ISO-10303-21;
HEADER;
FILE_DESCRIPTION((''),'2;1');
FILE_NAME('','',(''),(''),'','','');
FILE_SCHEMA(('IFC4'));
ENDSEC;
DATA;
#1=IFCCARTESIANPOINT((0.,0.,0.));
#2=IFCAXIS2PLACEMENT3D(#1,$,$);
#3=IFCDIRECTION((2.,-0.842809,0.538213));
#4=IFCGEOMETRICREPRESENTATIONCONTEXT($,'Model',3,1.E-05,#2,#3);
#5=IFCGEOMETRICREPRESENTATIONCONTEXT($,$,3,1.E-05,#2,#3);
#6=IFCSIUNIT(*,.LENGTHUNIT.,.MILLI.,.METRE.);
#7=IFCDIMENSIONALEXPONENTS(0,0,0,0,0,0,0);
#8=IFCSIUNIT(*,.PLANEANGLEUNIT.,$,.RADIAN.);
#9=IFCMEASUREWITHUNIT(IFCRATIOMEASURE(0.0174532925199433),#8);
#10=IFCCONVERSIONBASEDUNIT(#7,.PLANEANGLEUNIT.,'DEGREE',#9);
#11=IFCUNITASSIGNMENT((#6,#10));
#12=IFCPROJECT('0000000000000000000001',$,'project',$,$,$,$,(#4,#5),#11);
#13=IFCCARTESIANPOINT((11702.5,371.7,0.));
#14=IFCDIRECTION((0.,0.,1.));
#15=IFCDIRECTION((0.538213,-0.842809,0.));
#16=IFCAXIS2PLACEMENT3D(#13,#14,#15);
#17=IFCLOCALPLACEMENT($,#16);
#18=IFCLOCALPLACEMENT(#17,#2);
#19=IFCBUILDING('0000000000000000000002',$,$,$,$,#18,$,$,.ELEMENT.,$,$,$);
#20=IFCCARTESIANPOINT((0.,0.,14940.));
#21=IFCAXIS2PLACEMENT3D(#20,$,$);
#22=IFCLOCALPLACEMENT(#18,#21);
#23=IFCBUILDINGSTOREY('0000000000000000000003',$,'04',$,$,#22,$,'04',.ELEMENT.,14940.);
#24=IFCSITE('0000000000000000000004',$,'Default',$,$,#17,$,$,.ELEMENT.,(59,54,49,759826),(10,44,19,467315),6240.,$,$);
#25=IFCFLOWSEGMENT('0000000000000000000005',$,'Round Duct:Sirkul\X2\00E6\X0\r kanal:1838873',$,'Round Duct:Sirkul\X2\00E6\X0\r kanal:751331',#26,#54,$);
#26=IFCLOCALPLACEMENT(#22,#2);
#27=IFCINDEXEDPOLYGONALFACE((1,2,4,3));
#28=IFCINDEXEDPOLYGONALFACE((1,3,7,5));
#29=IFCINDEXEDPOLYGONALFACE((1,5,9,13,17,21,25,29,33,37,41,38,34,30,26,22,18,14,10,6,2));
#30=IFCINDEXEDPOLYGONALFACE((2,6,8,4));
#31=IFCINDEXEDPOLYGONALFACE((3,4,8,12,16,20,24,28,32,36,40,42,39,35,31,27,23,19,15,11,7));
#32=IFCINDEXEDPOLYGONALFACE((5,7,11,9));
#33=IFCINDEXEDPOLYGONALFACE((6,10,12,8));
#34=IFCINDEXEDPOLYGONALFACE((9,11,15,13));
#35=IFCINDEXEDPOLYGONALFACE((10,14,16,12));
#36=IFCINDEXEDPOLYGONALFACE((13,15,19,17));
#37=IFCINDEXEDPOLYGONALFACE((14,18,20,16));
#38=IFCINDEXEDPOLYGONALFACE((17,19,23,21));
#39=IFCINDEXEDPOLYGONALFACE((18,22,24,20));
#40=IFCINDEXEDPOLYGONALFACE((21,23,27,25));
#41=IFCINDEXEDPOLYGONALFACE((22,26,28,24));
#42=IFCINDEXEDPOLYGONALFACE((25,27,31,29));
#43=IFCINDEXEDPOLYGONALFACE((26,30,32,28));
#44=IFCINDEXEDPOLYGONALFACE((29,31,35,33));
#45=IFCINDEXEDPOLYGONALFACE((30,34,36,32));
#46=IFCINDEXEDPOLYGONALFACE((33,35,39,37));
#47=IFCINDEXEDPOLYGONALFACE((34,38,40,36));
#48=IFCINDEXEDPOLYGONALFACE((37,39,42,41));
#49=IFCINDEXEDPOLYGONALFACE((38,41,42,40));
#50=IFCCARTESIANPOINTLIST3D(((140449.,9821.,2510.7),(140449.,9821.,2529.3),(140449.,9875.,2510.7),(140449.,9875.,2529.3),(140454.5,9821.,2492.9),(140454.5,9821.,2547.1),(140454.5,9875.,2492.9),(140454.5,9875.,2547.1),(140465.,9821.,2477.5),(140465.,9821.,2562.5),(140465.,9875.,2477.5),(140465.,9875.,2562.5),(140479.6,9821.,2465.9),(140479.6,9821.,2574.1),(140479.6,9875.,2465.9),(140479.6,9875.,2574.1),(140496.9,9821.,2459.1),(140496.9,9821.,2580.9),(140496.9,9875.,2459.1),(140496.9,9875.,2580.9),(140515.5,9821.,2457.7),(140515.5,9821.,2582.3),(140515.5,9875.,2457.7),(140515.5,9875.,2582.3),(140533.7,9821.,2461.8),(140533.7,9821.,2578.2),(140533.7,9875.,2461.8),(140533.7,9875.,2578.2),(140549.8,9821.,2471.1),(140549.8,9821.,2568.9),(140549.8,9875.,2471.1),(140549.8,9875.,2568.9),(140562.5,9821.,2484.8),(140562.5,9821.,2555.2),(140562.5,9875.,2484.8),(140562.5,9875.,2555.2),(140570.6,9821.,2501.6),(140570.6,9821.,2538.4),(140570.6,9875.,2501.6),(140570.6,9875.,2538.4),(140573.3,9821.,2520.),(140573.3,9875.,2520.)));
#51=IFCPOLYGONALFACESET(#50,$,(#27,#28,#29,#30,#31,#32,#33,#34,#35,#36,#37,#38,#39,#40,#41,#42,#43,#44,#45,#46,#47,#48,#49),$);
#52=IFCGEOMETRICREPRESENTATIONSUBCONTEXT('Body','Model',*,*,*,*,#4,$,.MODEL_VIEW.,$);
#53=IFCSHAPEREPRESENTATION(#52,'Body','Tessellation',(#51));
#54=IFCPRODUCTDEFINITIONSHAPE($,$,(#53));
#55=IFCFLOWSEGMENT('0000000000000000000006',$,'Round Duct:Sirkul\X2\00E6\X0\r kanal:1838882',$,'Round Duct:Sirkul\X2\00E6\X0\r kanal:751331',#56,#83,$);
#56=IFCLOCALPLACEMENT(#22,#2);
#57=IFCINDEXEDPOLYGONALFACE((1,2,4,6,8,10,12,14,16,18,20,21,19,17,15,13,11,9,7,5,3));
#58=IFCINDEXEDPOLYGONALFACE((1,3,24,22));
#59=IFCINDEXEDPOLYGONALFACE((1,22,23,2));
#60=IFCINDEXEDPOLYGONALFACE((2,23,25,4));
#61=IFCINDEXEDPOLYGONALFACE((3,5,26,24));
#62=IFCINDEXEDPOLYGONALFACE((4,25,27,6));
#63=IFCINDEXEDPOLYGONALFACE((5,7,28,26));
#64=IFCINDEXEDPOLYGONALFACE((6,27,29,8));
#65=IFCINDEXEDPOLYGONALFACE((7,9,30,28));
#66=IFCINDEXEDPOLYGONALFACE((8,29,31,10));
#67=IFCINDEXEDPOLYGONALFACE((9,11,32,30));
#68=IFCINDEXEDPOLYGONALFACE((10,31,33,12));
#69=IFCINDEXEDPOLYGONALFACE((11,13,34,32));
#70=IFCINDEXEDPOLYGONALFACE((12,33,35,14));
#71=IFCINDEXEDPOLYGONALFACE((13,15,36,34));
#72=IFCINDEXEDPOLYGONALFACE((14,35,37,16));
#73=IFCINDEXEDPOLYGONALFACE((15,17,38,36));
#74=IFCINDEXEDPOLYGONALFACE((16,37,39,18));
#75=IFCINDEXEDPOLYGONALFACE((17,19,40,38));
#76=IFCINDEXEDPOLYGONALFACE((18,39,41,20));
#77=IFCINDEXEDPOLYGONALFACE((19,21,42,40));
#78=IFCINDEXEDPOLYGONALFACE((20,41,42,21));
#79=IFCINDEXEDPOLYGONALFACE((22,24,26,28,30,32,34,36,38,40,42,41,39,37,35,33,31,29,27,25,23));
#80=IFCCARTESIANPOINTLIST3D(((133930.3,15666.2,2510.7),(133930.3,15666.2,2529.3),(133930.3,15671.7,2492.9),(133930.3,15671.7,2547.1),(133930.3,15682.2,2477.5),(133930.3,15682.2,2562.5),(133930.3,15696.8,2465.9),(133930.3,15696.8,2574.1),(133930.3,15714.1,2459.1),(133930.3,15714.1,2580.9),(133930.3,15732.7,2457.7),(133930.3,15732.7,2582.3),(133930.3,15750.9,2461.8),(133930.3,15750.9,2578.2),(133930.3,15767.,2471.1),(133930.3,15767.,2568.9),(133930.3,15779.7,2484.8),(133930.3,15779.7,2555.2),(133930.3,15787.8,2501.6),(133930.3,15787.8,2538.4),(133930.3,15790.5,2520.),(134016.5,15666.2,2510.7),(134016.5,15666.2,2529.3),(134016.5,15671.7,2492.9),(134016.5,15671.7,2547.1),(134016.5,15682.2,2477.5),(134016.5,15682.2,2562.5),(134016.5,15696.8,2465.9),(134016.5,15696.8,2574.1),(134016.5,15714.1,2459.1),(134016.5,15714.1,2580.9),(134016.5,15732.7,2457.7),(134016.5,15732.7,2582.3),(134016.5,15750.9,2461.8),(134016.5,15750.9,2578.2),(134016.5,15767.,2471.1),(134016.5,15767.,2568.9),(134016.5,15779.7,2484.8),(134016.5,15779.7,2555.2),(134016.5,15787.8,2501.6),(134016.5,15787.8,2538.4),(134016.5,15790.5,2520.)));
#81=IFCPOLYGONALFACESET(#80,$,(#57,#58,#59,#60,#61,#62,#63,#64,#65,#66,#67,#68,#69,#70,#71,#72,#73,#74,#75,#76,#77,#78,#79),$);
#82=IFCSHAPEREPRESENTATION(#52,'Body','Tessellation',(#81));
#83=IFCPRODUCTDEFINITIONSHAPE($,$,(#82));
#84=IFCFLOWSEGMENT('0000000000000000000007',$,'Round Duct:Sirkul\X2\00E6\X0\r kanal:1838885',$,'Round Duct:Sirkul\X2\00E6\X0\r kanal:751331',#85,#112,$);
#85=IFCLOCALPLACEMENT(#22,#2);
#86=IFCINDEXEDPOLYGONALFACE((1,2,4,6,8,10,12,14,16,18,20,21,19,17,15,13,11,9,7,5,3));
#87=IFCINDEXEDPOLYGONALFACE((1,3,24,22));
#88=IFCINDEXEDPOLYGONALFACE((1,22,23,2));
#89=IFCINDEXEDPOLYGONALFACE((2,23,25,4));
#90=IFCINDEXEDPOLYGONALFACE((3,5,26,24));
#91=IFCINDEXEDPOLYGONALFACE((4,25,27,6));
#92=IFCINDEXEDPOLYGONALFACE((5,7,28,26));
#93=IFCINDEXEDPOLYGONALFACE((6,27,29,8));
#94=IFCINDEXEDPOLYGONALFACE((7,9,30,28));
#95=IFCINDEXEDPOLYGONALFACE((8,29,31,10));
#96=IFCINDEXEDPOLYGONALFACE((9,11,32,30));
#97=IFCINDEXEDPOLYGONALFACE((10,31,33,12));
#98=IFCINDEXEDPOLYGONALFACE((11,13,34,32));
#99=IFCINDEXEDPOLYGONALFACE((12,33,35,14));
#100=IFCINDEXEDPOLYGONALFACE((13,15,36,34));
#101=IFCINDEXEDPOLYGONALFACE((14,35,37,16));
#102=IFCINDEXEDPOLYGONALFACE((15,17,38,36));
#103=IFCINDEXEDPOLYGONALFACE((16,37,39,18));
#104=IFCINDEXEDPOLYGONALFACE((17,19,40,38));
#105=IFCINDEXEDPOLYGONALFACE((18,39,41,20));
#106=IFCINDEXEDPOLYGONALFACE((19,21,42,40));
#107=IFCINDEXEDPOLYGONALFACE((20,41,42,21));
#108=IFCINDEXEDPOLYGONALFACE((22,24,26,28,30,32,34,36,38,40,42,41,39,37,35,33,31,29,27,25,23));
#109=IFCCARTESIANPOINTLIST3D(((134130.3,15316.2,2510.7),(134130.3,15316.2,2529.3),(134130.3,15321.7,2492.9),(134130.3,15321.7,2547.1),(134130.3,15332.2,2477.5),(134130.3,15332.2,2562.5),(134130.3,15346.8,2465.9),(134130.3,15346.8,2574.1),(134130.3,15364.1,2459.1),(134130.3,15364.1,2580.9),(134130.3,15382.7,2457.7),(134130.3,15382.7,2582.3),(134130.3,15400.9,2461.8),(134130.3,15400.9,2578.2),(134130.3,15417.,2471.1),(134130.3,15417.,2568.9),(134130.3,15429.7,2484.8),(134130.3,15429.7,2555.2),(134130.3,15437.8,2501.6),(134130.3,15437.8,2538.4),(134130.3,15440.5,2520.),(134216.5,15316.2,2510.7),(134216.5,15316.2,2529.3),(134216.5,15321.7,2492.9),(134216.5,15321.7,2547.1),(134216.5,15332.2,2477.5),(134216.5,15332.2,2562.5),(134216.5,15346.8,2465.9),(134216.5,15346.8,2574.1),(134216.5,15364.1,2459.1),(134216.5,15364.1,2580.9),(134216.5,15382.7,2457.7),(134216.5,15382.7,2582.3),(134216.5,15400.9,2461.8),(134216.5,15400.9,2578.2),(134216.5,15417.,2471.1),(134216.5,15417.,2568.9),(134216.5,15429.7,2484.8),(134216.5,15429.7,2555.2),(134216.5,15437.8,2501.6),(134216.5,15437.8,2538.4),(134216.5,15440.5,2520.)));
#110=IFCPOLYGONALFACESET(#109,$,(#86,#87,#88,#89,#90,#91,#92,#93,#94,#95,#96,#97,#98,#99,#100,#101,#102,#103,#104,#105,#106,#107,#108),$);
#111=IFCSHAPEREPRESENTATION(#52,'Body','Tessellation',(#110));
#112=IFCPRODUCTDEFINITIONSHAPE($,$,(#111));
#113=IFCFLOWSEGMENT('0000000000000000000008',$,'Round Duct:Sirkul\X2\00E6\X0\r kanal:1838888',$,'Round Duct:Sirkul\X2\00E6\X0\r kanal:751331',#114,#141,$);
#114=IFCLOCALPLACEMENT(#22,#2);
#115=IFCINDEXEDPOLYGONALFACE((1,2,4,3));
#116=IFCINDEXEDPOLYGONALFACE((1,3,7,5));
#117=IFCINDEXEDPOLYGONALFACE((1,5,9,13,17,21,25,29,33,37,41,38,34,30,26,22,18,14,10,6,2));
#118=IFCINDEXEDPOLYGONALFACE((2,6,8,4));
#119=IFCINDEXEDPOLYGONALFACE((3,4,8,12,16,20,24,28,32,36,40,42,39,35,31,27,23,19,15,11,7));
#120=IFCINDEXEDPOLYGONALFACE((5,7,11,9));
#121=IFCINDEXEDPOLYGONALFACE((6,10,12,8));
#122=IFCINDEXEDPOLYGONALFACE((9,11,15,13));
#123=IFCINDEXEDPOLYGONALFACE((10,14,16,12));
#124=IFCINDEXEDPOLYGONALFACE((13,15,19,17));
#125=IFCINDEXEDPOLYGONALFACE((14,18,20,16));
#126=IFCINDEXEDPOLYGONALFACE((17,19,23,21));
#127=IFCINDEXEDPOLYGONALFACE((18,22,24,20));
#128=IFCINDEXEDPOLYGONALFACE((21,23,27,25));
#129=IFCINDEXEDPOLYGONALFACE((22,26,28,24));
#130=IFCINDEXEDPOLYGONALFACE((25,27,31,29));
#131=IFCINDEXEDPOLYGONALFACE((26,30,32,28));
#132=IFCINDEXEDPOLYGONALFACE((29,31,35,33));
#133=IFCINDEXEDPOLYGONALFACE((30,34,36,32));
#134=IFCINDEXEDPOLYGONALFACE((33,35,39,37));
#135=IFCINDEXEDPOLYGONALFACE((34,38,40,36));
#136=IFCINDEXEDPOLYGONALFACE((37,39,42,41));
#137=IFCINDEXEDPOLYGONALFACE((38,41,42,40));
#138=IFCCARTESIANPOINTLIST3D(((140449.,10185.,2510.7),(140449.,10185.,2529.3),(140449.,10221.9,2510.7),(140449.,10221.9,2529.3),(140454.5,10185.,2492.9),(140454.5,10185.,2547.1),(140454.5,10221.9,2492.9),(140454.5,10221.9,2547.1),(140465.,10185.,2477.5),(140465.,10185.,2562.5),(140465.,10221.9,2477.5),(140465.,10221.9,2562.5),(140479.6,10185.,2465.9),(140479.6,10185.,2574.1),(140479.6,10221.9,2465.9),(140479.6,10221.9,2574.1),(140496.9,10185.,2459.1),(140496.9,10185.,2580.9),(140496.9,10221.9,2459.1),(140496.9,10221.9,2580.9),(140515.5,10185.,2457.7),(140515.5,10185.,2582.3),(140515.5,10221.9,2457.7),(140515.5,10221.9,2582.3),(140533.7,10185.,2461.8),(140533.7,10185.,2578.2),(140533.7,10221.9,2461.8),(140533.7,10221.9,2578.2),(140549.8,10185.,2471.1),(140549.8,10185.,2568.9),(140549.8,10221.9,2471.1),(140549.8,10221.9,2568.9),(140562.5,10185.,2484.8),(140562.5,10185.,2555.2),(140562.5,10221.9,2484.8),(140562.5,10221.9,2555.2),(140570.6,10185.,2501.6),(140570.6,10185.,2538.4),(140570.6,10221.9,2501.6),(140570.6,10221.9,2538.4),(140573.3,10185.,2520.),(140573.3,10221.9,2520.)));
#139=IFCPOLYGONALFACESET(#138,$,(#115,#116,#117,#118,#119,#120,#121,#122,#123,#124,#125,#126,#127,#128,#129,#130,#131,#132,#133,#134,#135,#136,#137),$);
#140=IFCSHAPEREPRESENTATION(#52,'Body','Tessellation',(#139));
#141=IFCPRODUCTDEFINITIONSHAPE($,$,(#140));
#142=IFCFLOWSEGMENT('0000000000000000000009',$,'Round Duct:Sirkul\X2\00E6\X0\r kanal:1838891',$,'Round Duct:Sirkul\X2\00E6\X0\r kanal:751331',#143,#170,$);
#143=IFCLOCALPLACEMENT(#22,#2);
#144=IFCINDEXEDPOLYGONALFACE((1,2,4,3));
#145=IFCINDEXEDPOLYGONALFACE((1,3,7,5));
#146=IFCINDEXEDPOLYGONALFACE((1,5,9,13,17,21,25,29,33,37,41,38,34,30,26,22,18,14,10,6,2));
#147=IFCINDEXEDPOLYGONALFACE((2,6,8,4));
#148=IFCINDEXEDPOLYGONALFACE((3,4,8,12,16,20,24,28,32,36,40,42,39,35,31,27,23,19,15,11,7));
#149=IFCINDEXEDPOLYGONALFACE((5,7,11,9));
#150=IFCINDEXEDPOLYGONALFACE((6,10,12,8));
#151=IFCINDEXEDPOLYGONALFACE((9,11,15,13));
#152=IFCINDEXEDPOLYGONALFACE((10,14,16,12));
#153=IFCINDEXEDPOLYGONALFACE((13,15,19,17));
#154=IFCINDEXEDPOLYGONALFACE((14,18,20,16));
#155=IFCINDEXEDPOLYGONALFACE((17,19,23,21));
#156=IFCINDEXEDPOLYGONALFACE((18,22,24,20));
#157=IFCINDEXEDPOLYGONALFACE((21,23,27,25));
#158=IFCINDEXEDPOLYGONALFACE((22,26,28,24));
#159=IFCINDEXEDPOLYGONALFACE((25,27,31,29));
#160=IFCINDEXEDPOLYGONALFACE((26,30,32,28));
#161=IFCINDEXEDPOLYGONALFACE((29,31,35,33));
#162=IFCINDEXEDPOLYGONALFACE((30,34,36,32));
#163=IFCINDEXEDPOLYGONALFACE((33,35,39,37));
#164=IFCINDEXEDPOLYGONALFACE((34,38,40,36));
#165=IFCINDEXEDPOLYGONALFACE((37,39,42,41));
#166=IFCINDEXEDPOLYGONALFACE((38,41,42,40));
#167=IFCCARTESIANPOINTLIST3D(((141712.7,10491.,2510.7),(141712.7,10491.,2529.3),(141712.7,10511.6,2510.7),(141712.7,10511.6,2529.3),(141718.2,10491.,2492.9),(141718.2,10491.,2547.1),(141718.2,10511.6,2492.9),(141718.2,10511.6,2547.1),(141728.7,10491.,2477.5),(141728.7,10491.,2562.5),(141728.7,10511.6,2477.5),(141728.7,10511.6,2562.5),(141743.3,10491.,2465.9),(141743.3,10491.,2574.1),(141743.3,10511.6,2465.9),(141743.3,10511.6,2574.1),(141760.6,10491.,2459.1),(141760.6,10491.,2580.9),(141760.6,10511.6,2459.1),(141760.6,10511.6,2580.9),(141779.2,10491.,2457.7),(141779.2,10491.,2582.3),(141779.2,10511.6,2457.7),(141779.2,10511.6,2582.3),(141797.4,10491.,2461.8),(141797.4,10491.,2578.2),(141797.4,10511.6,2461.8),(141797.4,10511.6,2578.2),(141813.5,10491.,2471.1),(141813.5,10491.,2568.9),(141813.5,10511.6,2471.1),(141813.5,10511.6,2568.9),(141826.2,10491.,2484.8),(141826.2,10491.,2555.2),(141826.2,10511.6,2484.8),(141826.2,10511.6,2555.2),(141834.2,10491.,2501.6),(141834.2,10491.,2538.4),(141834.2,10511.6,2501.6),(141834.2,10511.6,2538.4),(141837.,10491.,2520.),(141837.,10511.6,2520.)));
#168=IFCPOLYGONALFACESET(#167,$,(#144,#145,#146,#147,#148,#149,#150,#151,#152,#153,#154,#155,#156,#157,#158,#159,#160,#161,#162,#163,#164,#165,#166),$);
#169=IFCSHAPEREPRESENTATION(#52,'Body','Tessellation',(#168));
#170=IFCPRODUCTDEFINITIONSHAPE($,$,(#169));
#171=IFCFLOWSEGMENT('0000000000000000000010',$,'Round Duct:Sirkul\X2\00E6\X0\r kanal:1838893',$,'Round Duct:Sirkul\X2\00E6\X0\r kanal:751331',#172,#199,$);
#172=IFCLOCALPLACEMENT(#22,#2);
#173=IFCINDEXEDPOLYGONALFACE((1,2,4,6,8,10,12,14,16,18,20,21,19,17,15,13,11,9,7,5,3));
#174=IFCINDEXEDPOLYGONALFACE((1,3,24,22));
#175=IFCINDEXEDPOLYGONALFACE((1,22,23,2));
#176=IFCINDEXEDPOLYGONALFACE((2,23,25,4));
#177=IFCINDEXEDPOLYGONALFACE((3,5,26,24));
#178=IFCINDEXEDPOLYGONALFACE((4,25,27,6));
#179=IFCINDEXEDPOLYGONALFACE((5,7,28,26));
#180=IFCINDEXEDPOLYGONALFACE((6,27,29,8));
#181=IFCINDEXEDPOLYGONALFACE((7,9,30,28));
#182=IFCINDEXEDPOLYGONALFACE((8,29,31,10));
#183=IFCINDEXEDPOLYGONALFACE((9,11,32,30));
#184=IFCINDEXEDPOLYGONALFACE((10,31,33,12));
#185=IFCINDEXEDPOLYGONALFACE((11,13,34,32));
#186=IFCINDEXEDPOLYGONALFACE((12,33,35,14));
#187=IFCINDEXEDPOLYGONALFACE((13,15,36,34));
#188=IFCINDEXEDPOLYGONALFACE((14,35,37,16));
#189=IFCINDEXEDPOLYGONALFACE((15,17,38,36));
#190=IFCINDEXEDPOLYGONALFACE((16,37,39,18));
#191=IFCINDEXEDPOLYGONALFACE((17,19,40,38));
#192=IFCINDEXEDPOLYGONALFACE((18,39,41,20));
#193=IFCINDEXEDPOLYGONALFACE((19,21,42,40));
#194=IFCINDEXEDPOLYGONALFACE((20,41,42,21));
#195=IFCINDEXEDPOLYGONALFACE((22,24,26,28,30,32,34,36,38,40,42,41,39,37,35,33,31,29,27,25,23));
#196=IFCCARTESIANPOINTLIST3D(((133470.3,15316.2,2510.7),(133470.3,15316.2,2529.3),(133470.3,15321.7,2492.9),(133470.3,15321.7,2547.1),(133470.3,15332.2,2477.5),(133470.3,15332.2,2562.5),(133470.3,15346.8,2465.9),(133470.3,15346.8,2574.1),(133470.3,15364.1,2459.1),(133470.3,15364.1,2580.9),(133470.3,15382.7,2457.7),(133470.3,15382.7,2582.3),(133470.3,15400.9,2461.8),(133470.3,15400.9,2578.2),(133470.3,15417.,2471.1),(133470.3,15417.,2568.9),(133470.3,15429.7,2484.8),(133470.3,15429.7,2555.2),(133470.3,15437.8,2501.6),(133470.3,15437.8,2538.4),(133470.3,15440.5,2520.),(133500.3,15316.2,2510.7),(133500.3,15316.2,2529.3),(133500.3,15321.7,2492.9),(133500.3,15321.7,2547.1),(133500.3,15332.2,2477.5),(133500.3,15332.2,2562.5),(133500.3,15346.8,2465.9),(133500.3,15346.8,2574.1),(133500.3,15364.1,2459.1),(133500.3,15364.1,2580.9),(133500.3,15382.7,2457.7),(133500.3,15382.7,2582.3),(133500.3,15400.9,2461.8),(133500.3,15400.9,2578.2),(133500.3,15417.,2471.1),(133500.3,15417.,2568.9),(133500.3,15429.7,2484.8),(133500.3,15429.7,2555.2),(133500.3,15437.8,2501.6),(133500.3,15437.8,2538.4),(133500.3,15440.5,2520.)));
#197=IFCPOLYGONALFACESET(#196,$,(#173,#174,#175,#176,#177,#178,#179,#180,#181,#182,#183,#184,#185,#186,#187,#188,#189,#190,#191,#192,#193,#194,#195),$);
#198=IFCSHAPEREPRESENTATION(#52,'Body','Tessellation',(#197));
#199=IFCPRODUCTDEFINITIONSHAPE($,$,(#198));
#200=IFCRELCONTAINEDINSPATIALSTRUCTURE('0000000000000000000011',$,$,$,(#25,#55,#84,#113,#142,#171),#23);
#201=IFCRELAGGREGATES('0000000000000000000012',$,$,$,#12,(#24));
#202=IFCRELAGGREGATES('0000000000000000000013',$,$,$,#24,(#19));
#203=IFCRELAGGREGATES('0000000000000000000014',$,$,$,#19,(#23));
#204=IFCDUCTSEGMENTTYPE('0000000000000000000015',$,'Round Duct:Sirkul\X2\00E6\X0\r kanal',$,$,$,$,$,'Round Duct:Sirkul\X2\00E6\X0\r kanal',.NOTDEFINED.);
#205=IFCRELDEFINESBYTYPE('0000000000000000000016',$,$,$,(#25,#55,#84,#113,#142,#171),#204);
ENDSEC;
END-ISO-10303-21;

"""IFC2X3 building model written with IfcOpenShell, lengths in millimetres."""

from ifc_helpers import new_model, entity, si_unit, converted_unit, direction, frame, frame_2d, origin, origin_2d_with_axis, place, context, subcontext, project, spatial, circle, extrude, type_object, element, save


model = new_model("IFC2X3")

# Units and contexts
model_context = context("Model", 3, precision=1e-05, world=origin(), true_north=direction((2.0, -0.842809, 0.538213)))
context_of_model = context(None, 3, precision=1e-05, world=origin(), true_north=direction((2.0, -0.842809, 0.538213)))
body_context = subcontext(model_context, "Body", "Model", "MODEL_VIEW")
ifc_project = project(units=[si_unit("LENGTHUNIT", "METRE", prefix="MILLI"), converted_unit("PLANEANGLEUNIT", "DEGREE", entity("IfcRatioMeasure", 0.0174532925199433), si_unit("PLANEANGLEUNIT", "RADIAN"), dimensions=[0, 0, 0, 0, 0, 0, 0])], contexts=[model_context, context_of_model])

# Site, building, storey
site_placement = place(None, frame((11702.5, 371.7, 0.0), z_axis=(0.0, 0.0, 1.0), x_axis=(0.538213, -0.842809, 0.0)))
site = spatial("IfcSite", under=ifc_project, at=site_placement, Name="Default", CompositionType="ELEMENT", RefLatitude=(59, 54, 49, 759826), RefLongitude=(10, 44, 19, 467315), RefElevation=6240.0)
building_placement = place(site_placement, origin())
building = spatial("IfcBuilding", under=site, at=building_placement, CompositionType="ELEMENT")
storey_placement = place(building_placement, frame((0.0, 0.0, 14940.0)))
storey = spatial("IfcBuildingStorey", under=building, at=storey_placement, Name="04", LongName="04", CompositionType="ELEMENT", Elevation=14940.0)

# Flow segments
duct_segment_type_1 = type_object("IfcDuctSegmentType", Name="Round Duct:Sirkulær kanal", ElementType="Round Duct:Sirkulær kanal", PredefinedType="NOTDEFINED")
flow_segment_1_placement = place(storey_placement, origin())
element("IfcFlowSegment", 1, at=flow_segment_1_placement, inside=storey, type_object=duct_segment_type_1, Name="Round Duct:Sirkulær kanal:1838873", ObjectType="Round Duct:Sirkulær kanal:751331", context=body_context, shape_type="SweptSolid", body=[
    extrude(circle(Radius=62.5, at=frame_2d((0.0, 0.0), x_axis=(1.0, 0.0))), frame((140510.8, 9821.0, 2520.0), z_axis=(0.0, 1.0, 0.0), x_axis=(1.0, 0.0, 0.0)), (0.0, 0.0, 1.0), 54.0),
])
flow_segment_2_placement = place(storey_placement, origin())
element("IfcFlowSegment", 2, at=flow_segment_2_placement, inside=storey, type_object=duct_segment_type_1, Name="Round Duct:Sirkulær kanal:1838882", ObjectType="Round Duct:Sirkulær kanal:751331", context=body_context, shape_type="SweptSolid", body=[
    extrude(circle(Radius=62.5, at=origin_2d_with_axis()), frame((133930.3, 15728.0, 2520.0), z_axis=(1.0, 0.0, 0.0), x_axis=(0.0, 1.0, 0.0)), (0.0, 0.0, 1.0), 86.2),
])
flow_segment_3_placement = place(storey_placement, origin())
element("IfcFlowSegment", 3, at=flow_segment_3_placement, inside=storey, type_object=duct_segment_type_1, Name="Round Duct:Sirkulær kanal:1838885", ObjectType="Round Duct:Sirkulær kanal:751331", context=body_context, shape_type="SweptSolid", body=[
    extrude(circle(Radius=62.5, at=origin_2d_with_axis()), frame((134130.3, 15378.0, 2520.0), z_axis=(1.0, 0.0, 0.0), x_axis=(0.0, 1.0, 0.0)), (0.0, 0.0, 1.0), 86.2),
])
flow_segment_4_placement = place(storey_placement, origin())
element("IfcFlowSegment", 4, at=flow_segment_4_placement, inside=storey, type_object=duct_segment_type_1, Name="Round Duct:Sirkulær kanal:1838888", ObjectType="Round Duct:Sirkulær kanal:751331", context=body_context, shape_type="SweptSolid", body=[
    extrude(circle(Radius=62.5, at=frame_2d((0.0, 0.0), x_axis=(1.0, 0.0))), frame((140510.8, 10185.0, 2520.0), z_axis=(0.0, 1.0, 0.0), x_axis=(1.0, 0.0, 0.0)), (0.0, 0.0, 1.0), 36.9),
])
flow_segment_5_placement = place(storey_placement, origin())
element("IfcFlowSegment", 5, at=flow_segment_5_placement, inside=storey, type_object=duct_segment_type_1, Name="Round Duct:Sirkulær kanal:1838891", ObjectType="Round Duct:Sirkulær kanal:751331", context=body_context, shape_type="SweptSolid", body=[
    extrude(circle(Radius=62.5, at=frame_2d((0.0, 0.0), x_axis=(1.0, 0.0))), frame((141774.5, 10491.0, 2520.0), z_axis=(0.0, 1.0, 0.0), x_axis=(1.0, 0.0, 0.0)), (0.0, 0.0, 1.0), 20.6),
])
flow_segment_6_placement = place(storey_placement, origin())
element("IfcFlowSegment", 6, at=flow_segment_6_placement, inside=storey, type_object=duct_segment_type_1, Name="Round Duct:Sirkulær kanal:1838893", ObjectType="Round Duct:Sirkulær kanal:751331", context=body_context, shape_type="SweptSolid", body=[
    extrude(circle(Radius=62.5, at=origin_2d_with_axis()), frame((133470.3, 15378.0, 2520.0), z_axis=(1.0, 0.0, 0.0), x_axis=(0.0, 1.0, 0.0)), (0.0, 0.0, 1.0), 30.0),
])

save(model, "model.ifc")
